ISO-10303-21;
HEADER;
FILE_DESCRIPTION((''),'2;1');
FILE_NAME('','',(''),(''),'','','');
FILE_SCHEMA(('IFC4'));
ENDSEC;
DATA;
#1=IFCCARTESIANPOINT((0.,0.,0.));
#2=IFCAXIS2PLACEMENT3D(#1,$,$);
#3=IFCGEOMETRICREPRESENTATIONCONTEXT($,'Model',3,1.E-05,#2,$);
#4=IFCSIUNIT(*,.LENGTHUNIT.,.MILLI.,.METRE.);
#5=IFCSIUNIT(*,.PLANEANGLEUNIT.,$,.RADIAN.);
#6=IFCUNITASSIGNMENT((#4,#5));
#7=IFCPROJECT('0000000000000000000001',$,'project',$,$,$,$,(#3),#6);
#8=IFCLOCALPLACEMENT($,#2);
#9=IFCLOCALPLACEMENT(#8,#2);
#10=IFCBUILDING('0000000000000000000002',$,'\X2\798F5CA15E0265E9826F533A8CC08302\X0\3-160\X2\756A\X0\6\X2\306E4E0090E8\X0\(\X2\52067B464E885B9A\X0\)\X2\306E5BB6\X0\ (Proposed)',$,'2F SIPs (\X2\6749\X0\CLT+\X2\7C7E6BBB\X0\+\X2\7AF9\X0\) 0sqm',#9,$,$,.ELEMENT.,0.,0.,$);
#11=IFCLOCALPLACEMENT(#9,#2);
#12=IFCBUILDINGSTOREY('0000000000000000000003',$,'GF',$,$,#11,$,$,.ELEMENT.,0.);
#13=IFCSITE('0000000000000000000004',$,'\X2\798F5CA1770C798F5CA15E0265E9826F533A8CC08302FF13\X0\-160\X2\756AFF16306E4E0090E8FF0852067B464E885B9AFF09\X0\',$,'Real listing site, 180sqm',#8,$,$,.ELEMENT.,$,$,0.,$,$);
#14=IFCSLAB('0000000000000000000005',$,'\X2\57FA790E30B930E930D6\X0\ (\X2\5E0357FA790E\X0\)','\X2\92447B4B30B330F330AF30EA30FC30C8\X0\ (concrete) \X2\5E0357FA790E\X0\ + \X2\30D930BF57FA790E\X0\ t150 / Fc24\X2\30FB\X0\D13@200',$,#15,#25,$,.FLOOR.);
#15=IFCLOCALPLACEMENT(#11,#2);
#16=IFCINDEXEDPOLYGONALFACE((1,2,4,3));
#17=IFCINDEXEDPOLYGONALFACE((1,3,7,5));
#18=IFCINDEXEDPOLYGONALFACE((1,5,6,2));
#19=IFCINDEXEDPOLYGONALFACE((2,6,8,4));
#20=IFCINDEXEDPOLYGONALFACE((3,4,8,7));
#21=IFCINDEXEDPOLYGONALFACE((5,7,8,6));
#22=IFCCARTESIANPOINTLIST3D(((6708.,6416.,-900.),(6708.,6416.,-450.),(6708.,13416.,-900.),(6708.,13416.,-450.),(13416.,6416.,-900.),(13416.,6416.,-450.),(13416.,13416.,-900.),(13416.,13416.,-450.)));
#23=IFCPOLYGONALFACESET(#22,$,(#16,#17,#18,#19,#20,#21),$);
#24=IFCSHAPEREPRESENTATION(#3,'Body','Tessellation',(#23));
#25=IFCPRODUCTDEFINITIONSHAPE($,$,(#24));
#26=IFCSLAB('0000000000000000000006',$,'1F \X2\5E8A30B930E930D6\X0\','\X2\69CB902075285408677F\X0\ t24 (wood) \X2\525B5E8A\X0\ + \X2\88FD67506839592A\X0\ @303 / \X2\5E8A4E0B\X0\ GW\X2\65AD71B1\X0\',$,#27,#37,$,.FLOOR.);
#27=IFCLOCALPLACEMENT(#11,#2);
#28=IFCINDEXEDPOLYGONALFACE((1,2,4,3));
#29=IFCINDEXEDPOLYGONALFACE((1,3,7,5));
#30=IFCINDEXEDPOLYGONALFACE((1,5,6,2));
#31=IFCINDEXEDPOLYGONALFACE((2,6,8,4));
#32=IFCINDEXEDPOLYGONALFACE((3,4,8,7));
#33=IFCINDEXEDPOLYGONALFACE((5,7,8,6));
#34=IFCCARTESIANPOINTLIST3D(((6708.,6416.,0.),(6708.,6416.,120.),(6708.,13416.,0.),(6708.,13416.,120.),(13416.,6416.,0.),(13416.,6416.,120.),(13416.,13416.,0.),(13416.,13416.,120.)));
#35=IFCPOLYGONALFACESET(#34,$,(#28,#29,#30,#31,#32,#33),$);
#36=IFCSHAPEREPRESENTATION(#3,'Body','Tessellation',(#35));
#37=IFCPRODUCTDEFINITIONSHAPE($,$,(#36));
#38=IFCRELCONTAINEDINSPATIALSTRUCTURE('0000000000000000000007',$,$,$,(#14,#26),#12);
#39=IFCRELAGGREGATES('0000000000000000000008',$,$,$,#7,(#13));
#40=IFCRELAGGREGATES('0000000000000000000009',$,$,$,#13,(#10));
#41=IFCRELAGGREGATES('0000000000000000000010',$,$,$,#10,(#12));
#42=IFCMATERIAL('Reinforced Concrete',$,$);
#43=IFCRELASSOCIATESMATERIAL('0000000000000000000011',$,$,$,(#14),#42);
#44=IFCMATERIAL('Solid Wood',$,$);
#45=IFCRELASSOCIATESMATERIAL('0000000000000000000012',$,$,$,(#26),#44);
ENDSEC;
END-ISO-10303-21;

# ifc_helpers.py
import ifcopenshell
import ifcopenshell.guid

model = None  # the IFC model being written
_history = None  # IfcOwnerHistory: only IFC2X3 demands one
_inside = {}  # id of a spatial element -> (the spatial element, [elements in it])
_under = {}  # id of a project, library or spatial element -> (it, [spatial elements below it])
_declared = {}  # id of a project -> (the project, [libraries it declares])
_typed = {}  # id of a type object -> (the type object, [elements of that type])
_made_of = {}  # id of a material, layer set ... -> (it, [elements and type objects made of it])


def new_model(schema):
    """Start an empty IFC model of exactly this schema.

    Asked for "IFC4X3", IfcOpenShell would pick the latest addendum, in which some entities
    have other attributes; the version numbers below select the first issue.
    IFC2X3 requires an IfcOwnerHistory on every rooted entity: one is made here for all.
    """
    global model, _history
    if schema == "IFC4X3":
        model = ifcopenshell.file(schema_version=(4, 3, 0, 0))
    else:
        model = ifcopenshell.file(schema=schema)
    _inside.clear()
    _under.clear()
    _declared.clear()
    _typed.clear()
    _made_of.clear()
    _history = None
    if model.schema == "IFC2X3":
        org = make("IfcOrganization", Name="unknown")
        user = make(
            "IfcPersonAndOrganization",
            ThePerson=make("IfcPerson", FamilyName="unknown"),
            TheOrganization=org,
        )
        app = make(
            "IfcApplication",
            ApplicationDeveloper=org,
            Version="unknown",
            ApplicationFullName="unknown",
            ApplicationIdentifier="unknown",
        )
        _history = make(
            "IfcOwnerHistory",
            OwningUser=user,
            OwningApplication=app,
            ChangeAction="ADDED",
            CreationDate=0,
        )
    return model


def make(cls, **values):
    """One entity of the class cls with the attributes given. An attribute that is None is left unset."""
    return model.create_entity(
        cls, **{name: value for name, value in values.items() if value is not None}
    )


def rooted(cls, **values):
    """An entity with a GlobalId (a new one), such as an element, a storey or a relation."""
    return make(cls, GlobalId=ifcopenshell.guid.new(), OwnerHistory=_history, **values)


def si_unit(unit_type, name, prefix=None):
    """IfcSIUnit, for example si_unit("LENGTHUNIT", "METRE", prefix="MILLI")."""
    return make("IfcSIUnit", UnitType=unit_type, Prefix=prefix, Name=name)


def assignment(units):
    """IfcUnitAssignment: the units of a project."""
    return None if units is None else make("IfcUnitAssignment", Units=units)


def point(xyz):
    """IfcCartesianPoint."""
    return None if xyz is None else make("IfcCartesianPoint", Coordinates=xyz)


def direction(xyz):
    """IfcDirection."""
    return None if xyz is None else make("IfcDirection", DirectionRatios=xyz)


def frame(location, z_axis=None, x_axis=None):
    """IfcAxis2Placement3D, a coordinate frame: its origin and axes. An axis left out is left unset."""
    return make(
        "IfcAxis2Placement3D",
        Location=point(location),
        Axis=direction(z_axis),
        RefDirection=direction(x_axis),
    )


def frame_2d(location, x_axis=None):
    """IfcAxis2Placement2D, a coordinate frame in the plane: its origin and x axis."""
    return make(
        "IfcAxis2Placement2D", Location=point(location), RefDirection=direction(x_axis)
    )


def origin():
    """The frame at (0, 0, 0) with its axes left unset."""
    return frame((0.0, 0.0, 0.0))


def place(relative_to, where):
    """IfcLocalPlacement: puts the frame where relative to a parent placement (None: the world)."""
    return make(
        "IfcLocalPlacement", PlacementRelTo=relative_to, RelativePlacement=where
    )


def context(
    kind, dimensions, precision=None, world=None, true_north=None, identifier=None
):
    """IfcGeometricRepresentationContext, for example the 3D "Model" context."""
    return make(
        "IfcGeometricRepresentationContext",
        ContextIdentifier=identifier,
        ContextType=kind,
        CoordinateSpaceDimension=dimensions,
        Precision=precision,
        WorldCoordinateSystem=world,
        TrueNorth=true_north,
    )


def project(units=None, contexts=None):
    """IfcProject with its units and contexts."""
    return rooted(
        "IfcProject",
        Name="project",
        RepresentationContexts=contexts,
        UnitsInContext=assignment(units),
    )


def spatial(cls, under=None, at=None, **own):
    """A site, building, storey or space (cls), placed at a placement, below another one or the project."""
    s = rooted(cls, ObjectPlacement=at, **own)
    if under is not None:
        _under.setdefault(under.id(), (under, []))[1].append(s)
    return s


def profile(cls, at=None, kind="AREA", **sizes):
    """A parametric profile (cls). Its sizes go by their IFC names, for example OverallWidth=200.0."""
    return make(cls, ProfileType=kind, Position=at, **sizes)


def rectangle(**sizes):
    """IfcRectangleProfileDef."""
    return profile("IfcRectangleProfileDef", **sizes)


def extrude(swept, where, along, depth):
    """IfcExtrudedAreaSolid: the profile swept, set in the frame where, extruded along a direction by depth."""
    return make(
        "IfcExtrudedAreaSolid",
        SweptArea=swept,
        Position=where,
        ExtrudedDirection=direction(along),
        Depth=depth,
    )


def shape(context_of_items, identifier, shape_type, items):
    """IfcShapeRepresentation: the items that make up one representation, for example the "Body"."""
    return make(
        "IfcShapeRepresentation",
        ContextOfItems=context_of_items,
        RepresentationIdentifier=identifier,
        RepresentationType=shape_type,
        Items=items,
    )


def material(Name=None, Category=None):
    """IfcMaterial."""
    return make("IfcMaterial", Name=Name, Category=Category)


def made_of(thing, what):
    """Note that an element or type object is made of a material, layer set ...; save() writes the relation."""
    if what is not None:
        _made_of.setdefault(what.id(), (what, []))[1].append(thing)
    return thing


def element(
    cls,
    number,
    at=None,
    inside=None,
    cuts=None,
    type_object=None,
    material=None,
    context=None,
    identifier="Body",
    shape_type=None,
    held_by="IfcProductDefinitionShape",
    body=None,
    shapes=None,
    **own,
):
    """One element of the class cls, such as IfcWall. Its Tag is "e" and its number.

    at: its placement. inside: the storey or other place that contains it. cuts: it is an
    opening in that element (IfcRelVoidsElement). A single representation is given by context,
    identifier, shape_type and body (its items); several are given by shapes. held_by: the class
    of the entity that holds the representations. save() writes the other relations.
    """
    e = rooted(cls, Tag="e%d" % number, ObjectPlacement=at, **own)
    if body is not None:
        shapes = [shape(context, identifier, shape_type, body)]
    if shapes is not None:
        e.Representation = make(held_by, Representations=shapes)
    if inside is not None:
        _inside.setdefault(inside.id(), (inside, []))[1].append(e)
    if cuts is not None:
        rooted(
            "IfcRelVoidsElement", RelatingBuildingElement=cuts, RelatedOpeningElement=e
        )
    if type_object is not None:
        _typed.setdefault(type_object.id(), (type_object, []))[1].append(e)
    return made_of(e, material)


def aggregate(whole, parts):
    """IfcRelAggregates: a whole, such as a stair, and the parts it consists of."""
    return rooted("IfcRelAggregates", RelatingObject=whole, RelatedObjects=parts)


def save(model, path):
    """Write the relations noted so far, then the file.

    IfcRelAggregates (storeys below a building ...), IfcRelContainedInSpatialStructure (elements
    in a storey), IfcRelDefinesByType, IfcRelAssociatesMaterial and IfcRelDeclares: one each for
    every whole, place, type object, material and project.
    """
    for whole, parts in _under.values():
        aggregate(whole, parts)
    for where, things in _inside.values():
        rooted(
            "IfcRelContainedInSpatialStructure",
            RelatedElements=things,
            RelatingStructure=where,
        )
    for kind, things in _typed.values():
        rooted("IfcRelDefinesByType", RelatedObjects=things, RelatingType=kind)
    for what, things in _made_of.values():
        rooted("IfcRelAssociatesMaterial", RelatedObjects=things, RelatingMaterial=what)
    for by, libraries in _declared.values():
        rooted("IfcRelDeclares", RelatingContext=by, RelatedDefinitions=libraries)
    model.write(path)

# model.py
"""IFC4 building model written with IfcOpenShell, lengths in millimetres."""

from ifc_helpers import new_model, si_unit, frame, frame_2d, origin, place, context, project, spatial, rectangle, extrude, material, element, save


model = new_model("IFC4")

# Units and contexts
model_context = context("Model", 3, precision=1e-05, world=origin())
ifc_project = project(units=[si_unit("LENGTHUNIT", "METRE", prefix="MILLI"), si_unit("PLANEANGLEUNIT", "RADIAN")], contexts=[model_context])

# Site, building, storey
site_placement = place(None, origin())
site = spatial("IfcSite", under=ifc_project, at=site_placement, Name="福岡県福岡市早良区賀茂３-160番６の一部（分筆予定）", ObjectType="Real listing site, 180sqm", CompositionType="ELEMENT", RefElevation=0.0)
building_placement = place(site_placement, origin())
building = spatial("IfcBuilding", under=site, at=building_placement, Name="福岡市早良区賀茂3-160番6の一部(分筆予定)の家 (Proposed)", ObjectType="2F SIPs (杉CLT+籾殻+竹) 0sqm", CompositionType="ELEMENT", ElevationOfRefHeight=0.0, ElevationOfTerrain=0.0)
storey_placement = place(building_placement, origin())
storey = spatial("IfcBuildingStorey", under=building, at=storey_placement, Name="GF", CompositionType="ELEMENT", Elevation=0.0)

# Slabs
ifc_material_1 = material(Name="Reinforced Concrete")
slab_1_placement = place(storey_placement, frame((3354.0, 3208.0, -450.0)))
element("IfcSlab", 1, at=slab_1_placement, inside=storey, material=ifc_material_1, Name="基礎スラブ (布基礎)", Description="鉄筋コンクリート (concrete) 布基礎 + ベタ基礎 t150 / Fc24・D13@200", PredefinedType="FLOOR", context=model_context, shape_type="SweptSolid", body=[
    extrude(rectangle(XDim=6708.0, YDim=7000.0, at=frame_2d((3354.0, 3500.0))), frame((3354.0, 3208.0, -450.0)), (0.0, 0.0, 1.0), 450.0),
])
ifc_material_2 = material(Name="Solid Wood")
slab_2_placement = place(storey_placement, frame((3354.0, 3208.0, 0.0)))
element("IfcSlab", 2, at=slab_2_placement, inside=storey, material=ifc_material_2, Name="1F 床スラブ", Description="構造用合板 t24 (wood) 剛床 + 製材根太 @303 / 床下 GW断熱", PredefinedType="FLOOR", context=model_context, shape_type="SweptSolid", body=[
    extrude(rectangle(XDim=6708.0, YDim=7000.0, at=frame_2d((3354.0, 3500.0))), frame((3354.0, 3208.0, 0.0)), (0.0, 0.0, 1.0), 120.0),
])

save(model, "model.ifc")
